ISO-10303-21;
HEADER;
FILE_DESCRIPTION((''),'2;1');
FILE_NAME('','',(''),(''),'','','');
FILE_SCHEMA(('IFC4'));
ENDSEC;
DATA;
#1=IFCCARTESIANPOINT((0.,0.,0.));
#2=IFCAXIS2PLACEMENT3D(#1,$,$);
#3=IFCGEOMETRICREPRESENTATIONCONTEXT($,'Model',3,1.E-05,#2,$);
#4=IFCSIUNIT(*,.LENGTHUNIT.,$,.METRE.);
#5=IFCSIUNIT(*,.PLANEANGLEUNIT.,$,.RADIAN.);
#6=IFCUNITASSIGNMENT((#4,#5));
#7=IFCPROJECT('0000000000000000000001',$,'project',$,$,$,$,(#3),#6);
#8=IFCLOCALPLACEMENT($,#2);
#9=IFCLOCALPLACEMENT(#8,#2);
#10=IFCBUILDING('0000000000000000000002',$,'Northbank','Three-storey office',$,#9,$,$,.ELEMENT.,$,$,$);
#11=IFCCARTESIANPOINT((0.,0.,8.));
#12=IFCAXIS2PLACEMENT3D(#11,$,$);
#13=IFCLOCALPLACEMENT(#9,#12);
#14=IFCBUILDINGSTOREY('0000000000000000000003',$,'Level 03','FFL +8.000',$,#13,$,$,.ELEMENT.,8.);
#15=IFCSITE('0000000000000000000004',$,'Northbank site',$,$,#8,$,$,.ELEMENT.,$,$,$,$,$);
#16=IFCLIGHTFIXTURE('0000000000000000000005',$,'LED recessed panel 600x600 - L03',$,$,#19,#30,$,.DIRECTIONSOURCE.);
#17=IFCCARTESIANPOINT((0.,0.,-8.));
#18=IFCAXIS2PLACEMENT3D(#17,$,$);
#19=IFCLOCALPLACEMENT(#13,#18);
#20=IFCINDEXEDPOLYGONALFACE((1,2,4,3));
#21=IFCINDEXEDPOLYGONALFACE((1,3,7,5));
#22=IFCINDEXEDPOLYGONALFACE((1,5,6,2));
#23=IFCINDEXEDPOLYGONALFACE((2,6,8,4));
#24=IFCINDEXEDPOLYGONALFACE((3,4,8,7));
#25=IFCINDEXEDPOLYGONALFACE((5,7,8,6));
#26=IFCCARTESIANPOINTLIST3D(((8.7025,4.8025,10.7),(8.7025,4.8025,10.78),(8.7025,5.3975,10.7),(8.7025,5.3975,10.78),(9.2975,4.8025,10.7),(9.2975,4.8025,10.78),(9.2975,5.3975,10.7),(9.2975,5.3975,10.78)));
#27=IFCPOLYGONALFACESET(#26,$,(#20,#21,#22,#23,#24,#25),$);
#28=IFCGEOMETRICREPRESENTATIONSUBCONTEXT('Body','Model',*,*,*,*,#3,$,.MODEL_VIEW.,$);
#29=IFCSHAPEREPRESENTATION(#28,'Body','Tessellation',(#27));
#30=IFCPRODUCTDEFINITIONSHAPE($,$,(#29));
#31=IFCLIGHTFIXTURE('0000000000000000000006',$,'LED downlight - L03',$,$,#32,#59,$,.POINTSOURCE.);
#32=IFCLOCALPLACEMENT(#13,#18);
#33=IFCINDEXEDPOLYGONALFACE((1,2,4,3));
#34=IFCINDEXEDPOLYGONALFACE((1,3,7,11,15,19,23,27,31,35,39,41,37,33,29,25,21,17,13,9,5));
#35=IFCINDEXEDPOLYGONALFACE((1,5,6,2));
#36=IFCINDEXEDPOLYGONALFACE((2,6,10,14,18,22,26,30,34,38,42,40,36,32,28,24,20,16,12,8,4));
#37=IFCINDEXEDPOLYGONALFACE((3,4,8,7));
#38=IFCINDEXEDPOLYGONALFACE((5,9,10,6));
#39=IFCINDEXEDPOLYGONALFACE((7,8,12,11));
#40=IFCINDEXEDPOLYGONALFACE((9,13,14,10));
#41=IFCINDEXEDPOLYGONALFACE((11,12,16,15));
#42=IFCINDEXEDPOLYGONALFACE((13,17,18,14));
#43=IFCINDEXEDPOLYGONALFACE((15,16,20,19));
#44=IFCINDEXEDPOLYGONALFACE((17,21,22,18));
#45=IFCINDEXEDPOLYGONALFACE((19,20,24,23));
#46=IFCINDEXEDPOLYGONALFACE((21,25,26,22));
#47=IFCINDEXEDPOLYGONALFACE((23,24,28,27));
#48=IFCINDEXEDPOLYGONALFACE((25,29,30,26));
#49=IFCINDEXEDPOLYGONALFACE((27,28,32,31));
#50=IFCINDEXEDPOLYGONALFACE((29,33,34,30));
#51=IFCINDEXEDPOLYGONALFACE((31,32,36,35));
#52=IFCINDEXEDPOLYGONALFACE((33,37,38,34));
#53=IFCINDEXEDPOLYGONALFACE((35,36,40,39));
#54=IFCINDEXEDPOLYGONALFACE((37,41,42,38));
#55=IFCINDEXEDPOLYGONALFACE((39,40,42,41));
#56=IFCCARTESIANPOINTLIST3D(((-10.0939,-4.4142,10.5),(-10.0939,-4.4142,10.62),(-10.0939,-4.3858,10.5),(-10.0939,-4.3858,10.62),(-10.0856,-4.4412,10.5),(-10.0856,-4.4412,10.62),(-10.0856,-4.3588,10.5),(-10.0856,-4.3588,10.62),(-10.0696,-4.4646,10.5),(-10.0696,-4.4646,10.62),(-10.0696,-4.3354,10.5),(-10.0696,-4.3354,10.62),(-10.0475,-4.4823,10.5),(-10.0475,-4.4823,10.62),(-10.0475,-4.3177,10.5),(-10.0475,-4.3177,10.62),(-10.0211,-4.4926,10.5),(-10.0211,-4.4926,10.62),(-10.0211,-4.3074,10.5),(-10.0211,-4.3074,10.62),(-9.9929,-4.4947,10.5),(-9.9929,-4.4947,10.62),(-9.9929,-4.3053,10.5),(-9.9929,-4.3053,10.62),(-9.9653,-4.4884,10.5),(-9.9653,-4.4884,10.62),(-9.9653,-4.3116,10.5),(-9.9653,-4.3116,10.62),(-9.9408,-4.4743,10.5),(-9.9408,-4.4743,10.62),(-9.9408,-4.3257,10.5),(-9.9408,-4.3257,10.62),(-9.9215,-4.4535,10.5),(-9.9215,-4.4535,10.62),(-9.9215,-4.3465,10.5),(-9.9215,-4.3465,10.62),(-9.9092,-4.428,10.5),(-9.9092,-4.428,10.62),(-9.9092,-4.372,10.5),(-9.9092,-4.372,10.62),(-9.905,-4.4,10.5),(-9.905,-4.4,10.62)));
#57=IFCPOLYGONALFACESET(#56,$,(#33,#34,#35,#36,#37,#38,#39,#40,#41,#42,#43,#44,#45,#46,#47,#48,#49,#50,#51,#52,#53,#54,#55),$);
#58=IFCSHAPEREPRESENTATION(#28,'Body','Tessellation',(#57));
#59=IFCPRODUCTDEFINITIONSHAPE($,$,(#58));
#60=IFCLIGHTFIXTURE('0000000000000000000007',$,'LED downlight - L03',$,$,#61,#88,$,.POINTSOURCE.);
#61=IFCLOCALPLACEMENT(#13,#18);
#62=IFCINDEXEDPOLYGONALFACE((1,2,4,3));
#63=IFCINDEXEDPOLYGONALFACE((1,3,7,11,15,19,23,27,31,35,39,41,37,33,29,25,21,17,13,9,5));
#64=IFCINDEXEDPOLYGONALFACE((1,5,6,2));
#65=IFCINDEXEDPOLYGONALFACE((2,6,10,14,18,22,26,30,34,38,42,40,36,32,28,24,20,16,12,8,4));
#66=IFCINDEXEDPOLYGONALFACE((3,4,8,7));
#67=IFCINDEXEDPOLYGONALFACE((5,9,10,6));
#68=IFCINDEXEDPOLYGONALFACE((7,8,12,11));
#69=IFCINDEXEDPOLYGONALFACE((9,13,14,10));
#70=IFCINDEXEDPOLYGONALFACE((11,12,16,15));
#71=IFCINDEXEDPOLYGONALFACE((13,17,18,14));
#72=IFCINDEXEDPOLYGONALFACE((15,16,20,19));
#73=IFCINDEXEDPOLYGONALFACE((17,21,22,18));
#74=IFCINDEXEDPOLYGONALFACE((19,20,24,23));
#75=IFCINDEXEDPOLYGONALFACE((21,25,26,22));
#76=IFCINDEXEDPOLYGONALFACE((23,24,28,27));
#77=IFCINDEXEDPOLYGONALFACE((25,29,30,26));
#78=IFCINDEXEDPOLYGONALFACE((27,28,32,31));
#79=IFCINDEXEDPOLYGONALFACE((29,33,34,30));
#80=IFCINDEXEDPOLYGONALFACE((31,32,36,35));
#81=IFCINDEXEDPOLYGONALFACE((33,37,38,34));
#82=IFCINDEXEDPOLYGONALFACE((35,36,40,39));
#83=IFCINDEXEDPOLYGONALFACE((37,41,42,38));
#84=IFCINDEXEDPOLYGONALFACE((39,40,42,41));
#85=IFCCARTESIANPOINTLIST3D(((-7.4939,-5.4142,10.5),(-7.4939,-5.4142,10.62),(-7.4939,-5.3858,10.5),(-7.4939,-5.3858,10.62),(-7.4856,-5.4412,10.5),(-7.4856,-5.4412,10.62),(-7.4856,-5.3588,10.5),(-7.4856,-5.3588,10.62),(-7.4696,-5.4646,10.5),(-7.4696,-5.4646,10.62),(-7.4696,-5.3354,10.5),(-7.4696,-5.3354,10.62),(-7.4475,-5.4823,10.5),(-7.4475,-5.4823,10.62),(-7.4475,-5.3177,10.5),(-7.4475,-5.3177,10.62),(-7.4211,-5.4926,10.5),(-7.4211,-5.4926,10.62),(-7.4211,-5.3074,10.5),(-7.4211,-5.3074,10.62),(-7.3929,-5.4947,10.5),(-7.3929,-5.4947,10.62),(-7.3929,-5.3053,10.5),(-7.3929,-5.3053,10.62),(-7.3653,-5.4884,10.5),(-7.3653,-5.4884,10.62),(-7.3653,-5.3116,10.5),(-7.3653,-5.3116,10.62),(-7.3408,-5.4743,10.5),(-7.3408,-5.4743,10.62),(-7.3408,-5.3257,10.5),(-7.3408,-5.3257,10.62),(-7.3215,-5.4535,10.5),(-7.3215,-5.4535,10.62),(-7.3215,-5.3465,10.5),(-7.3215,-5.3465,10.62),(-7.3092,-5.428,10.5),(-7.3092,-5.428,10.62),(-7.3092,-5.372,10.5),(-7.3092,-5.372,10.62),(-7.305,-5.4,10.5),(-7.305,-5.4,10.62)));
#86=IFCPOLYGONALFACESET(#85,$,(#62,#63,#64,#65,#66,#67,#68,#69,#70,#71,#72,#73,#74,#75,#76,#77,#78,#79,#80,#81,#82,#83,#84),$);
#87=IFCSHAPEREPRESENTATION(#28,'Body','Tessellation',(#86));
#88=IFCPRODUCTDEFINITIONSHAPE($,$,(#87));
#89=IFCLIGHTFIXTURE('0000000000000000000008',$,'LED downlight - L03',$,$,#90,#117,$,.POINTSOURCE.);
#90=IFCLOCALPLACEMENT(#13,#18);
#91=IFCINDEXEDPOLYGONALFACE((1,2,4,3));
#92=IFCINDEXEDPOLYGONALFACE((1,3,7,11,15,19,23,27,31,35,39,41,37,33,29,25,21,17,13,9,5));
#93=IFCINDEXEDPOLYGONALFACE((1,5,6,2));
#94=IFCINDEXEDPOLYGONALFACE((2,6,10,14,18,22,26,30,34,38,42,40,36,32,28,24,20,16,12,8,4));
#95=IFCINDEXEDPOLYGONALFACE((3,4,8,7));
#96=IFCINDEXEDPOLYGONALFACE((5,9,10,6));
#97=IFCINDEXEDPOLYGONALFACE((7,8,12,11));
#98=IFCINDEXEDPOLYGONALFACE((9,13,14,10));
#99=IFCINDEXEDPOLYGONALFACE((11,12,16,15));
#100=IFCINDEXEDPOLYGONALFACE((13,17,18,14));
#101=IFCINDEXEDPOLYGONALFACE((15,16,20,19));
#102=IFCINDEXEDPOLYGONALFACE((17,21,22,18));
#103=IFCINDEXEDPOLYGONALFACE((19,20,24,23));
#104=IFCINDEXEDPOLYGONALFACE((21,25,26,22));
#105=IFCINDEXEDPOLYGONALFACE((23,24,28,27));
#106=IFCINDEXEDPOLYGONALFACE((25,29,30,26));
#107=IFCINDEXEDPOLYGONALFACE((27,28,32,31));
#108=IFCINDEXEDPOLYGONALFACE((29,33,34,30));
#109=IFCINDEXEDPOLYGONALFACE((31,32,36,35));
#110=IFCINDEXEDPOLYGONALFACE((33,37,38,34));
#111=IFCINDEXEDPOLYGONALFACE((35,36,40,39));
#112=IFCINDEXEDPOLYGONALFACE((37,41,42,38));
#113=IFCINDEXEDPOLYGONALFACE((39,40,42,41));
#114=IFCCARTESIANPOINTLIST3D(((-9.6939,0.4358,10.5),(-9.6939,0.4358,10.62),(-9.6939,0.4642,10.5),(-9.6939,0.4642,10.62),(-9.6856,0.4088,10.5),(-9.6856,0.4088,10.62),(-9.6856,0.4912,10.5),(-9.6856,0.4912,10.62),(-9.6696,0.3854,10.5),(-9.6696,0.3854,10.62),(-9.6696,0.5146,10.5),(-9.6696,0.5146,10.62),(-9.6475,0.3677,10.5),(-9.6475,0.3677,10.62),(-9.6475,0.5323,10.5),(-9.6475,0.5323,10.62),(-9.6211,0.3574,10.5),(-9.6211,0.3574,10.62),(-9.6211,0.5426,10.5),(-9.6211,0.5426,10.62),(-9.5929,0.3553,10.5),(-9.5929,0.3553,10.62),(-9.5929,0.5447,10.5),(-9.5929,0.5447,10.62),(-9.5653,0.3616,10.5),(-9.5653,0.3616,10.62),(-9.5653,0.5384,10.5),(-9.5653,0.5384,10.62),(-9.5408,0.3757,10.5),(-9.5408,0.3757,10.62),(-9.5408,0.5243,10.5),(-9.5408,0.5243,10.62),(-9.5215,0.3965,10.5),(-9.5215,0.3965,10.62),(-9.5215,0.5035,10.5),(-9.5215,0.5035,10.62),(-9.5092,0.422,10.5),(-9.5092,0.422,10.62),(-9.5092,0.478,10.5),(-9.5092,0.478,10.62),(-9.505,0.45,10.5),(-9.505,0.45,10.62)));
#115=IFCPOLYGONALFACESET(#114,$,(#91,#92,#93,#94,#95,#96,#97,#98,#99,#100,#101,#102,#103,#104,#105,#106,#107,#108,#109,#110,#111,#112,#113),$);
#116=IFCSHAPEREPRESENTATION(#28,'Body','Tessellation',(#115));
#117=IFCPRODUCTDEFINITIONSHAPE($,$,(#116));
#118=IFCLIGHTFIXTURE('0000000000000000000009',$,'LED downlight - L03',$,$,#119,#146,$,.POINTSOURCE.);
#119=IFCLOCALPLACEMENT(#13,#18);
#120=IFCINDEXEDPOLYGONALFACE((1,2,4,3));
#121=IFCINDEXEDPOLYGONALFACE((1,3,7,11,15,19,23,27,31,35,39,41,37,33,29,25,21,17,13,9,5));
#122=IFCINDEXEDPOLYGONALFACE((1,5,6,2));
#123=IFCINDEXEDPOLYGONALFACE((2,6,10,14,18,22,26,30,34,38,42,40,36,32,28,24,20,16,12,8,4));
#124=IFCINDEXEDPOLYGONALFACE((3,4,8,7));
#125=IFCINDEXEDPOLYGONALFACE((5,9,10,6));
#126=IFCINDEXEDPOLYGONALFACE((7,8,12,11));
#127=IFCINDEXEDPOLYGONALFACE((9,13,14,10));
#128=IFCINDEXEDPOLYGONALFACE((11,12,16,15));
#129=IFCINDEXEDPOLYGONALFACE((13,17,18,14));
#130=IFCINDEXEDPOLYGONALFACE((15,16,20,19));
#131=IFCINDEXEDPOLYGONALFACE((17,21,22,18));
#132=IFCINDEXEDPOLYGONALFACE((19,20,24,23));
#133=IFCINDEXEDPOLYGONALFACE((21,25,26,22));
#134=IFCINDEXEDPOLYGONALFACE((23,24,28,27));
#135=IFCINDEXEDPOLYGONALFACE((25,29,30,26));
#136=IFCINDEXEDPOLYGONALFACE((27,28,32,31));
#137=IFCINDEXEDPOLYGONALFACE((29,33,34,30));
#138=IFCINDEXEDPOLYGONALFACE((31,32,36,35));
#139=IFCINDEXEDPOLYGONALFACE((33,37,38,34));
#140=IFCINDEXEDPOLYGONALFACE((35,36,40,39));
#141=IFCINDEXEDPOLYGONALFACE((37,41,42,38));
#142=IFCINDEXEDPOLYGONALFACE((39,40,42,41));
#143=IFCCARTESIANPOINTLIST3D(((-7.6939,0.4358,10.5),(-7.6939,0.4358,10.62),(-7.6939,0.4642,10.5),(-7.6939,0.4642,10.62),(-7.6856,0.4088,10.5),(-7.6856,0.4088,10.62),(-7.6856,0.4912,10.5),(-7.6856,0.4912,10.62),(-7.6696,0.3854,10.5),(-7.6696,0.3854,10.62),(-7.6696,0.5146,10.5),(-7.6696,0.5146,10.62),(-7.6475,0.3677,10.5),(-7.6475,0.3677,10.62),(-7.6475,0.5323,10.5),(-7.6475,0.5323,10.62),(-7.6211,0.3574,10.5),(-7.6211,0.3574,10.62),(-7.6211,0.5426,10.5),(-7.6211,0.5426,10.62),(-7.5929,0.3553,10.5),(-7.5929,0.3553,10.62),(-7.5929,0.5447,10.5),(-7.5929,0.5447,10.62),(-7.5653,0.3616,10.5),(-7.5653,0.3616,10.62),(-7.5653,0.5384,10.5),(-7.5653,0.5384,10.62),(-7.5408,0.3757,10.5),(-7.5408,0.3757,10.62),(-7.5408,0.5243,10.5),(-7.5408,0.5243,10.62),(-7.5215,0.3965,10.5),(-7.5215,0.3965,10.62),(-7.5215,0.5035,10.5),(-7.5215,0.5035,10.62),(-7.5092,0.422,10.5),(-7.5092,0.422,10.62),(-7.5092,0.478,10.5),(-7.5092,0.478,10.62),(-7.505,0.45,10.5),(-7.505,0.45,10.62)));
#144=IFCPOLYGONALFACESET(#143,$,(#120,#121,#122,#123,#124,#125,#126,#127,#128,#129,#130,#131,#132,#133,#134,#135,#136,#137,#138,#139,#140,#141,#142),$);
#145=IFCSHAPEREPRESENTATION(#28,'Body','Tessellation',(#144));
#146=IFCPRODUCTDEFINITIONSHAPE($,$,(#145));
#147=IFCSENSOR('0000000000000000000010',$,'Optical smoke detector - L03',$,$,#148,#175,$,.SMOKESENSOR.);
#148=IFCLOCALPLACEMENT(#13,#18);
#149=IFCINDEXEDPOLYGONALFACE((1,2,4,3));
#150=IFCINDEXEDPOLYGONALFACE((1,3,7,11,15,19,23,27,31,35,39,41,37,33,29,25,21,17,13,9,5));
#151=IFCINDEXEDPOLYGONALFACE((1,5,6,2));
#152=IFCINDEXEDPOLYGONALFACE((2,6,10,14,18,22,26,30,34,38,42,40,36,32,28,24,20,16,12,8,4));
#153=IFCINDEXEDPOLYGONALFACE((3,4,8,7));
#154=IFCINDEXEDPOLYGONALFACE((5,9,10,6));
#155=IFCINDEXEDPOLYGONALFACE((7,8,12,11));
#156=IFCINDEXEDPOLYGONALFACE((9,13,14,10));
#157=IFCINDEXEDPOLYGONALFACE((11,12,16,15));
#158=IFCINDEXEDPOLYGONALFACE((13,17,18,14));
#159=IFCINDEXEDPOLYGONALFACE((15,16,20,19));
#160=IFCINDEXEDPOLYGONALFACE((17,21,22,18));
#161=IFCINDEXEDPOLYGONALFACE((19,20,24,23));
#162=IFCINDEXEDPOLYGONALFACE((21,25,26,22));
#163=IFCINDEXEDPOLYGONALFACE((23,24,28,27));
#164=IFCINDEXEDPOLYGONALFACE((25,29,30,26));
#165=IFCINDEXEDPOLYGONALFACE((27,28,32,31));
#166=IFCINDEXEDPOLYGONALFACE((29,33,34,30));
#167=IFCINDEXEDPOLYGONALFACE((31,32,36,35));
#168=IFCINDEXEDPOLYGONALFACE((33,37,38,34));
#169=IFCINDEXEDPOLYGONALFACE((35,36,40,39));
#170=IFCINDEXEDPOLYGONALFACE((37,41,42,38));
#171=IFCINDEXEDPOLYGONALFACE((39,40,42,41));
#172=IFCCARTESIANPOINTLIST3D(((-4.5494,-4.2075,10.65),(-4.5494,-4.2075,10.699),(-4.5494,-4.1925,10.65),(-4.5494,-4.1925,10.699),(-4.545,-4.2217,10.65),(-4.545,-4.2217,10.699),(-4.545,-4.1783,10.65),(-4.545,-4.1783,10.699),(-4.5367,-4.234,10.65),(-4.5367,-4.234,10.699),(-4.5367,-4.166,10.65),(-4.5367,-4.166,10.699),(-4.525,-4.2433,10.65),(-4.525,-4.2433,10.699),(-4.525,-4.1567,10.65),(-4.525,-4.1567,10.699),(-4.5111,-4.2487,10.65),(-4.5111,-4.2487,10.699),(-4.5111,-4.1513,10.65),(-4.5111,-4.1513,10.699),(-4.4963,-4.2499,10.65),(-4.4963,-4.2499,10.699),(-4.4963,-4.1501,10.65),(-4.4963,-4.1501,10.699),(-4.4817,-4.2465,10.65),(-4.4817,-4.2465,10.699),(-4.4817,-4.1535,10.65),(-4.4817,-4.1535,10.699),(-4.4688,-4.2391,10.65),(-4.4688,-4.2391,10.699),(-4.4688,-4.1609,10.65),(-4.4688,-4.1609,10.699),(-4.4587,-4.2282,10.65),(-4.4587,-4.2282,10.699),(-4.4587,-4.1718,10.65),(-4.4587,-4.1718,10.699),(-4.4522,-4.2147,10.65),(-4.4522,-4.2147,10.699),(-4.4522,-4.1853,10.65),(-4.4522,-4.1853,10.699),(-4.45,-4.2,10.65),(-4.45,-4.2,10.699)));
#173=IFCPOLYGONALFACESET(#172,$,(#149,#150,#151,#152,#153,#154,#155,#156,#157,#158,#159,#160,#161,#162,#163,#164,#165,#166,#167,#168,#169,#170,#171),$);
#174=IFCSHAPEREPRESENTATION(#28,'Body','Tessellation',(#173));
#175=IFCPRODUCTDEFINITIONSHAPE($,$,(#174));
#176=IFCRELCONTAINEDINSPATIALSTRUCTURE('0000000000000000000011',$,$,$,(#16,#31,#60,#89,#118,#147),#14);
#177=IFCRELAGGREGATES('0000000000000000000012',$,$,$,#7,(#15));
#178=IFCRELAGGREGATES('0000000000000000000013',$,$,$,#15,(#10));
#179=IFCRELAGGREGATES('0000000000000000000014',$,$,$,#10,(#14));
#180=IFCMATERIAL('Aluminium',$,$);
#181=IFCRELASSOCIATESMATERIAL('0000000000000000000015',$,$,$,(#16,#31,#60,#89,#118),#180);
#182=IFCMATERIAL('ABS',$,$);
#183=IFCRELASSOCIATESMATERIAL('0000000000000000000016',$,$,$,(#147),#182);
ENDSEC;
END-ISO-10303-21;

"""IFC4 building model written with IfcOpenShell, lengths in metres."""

from ifc_helpers import new_model, si_unit, frame, origin, place, context, subcontext, project, spatial, rectangle, circle, extrude, material, element, save


model = new_model("IFC4")

# Units and contexts
model_context = context("Model", 3, precision=1e-05, world=origin())
body_context = subcontext(model_context, "Body", "Model", "MODEL_VIEW")
ifc_project = project(units=[si_unit("LENGTHUNIT", "METRE"), si_unit("PLANEANGLEUNIT", "RADIAN")], contexts=[model_context])

# Site, building, storey
site_placement = place(None, origin())
site = spatial("IfcSite", under=ifc_project, at=site_placement, Name="Northbank site", CompositionType="ELEMENT")
building_placement = place(site_placement, origin())
building = spatial("IfcBuilding", under=site, at=building_placement, Name="Northbank", Description="Three-storey office", CompositionType="ELEMENT")
storey_placement = place(building_placement, frame((0.0, 0.0, 8.0)))
storey = spatial("IfcBuildingStorey", under=building, at=storey_placement, Name="Level 03", Description="FFL +8.000", CompositionType="ELEMENT", Elevation=8.0)

# Light fixtures
ifc_material_1 = material(Name="Aluminium")
light_fixture_1_placement = place(storey_placement, frame((0.0, 0.0, -8.0)))
element("IfcLightFixture", 1, at=light_fixture_1_placement, inside=storey, material=ifc_material_1, Name="LED recessed panel 600x600 - L03", PredefinedType="DIRECTIONSOURCE", context=body_context, shape_type="SweptSolid", body=[
    extrude(rectangle(XDim=0.595, YDim=0.595), frame((9.0, 5.1, 10.7)), (0.0, 0.0, 1.0), 0.08),
])
light_fixture_2_placement = place(storey_placement, frame((0.0, 0.0, -8.0)))
element("IfcLightFixture", 2, at=light_fixture_2_placement, inside=storey, material=ifc_material_1, Name="LED downlight - L03", PredefinedType="POINTSOURCE", context=body_context, shape_type="SweptSolid", body=[
    extrude(circle(Radius=0.095), frame((-10.0, -4.4, 10.5), z_axis=(0.0, 0.0, 1.0), x_axis=(1.0, 0.0, 0.0)), (0.0, 0.0, 1.0), 0.12),
])
light_fixture_3_placement = place(storey_placement, frame((0.0, 0.0, -8.0)))
element("IfcLightFixture", 3, at=light_fixture_3_placement, inside=storey, material=ifc_material_1, Name="LED downlight - L03", PredefinedType="POINTSOURCE", context=body_context, shape_type="SweptSolid", body=[
    extrude(circle(Radius=0.095), frame((-7.4, -5.4, 10.5), z_axis=(0.0, 0.0, 1.0), x_axis=(1.0, 0.0, 0.0)), (0.0, 0.0, 1.0), 0.12),
])
light_fixture_4_placement = place(storey_placement, frame((0.0, 0.0, -8.0)))
element("IfcLightFixture", 4, at=light_fixture_4_placement, inside=storey, material=ifc_material_1, Name="LED downlight - L03", PredefinedType="POINTSOURCE", context=body_context, shape_type="SweptSolid", body=[
    extrude(circle(Radius=0.095), frame((-9.6, 0.45, 10.5), z_axis=(0.0, 0.0, 1.0), x_axis=(1.0, 0.0, 0.0)), (0.0, 0.0, 1.0), 0.12),
])
light_fixture_5_placement = place(storey_placement, frame((0.0, 0.0, -8.0)))
element("IfcLightFixture", 5, at=light_fixture_5_placement, inside=storey, material=ifc_material_1, Name="LED downlight - L03", PredefinedType="POINTSOURCE", context=body_context, shape_type="SweptSolid", body=[
    extrude(circle(Radius=0.095), frame((-7.6, 0.45, 10.5), z_axis=(0.0, 0.0, 1.0), x_axis=(1.0, 0.0, 0.0)), (0.0, 0.0, 1.0), 0.12),
])

# Sensor
ifc_material_2 = material(Name="ABS")
sensor_1_placement = place(storey_placement, frame((0.0, 0.0, -8.0)))
element("IfcSensor", 6, at=sensor_1_placement, inside=storey, material=ifc_material_2, Name="Optical smoke detector - L03", PredefinedType="SMOKESENSOR", context=body_context, shape_type="SweptSolid", body=[
    extrude(circle(Radius=0.05), frame((-4.5, -4.2, 10.65), z_axis=(0.0, 0.0, 1.0), x_axis=(1.0, 0.0, 0.0)), (0.0, 0.0, 1.0), 0.049),
])

save(model, "model.ifc")
